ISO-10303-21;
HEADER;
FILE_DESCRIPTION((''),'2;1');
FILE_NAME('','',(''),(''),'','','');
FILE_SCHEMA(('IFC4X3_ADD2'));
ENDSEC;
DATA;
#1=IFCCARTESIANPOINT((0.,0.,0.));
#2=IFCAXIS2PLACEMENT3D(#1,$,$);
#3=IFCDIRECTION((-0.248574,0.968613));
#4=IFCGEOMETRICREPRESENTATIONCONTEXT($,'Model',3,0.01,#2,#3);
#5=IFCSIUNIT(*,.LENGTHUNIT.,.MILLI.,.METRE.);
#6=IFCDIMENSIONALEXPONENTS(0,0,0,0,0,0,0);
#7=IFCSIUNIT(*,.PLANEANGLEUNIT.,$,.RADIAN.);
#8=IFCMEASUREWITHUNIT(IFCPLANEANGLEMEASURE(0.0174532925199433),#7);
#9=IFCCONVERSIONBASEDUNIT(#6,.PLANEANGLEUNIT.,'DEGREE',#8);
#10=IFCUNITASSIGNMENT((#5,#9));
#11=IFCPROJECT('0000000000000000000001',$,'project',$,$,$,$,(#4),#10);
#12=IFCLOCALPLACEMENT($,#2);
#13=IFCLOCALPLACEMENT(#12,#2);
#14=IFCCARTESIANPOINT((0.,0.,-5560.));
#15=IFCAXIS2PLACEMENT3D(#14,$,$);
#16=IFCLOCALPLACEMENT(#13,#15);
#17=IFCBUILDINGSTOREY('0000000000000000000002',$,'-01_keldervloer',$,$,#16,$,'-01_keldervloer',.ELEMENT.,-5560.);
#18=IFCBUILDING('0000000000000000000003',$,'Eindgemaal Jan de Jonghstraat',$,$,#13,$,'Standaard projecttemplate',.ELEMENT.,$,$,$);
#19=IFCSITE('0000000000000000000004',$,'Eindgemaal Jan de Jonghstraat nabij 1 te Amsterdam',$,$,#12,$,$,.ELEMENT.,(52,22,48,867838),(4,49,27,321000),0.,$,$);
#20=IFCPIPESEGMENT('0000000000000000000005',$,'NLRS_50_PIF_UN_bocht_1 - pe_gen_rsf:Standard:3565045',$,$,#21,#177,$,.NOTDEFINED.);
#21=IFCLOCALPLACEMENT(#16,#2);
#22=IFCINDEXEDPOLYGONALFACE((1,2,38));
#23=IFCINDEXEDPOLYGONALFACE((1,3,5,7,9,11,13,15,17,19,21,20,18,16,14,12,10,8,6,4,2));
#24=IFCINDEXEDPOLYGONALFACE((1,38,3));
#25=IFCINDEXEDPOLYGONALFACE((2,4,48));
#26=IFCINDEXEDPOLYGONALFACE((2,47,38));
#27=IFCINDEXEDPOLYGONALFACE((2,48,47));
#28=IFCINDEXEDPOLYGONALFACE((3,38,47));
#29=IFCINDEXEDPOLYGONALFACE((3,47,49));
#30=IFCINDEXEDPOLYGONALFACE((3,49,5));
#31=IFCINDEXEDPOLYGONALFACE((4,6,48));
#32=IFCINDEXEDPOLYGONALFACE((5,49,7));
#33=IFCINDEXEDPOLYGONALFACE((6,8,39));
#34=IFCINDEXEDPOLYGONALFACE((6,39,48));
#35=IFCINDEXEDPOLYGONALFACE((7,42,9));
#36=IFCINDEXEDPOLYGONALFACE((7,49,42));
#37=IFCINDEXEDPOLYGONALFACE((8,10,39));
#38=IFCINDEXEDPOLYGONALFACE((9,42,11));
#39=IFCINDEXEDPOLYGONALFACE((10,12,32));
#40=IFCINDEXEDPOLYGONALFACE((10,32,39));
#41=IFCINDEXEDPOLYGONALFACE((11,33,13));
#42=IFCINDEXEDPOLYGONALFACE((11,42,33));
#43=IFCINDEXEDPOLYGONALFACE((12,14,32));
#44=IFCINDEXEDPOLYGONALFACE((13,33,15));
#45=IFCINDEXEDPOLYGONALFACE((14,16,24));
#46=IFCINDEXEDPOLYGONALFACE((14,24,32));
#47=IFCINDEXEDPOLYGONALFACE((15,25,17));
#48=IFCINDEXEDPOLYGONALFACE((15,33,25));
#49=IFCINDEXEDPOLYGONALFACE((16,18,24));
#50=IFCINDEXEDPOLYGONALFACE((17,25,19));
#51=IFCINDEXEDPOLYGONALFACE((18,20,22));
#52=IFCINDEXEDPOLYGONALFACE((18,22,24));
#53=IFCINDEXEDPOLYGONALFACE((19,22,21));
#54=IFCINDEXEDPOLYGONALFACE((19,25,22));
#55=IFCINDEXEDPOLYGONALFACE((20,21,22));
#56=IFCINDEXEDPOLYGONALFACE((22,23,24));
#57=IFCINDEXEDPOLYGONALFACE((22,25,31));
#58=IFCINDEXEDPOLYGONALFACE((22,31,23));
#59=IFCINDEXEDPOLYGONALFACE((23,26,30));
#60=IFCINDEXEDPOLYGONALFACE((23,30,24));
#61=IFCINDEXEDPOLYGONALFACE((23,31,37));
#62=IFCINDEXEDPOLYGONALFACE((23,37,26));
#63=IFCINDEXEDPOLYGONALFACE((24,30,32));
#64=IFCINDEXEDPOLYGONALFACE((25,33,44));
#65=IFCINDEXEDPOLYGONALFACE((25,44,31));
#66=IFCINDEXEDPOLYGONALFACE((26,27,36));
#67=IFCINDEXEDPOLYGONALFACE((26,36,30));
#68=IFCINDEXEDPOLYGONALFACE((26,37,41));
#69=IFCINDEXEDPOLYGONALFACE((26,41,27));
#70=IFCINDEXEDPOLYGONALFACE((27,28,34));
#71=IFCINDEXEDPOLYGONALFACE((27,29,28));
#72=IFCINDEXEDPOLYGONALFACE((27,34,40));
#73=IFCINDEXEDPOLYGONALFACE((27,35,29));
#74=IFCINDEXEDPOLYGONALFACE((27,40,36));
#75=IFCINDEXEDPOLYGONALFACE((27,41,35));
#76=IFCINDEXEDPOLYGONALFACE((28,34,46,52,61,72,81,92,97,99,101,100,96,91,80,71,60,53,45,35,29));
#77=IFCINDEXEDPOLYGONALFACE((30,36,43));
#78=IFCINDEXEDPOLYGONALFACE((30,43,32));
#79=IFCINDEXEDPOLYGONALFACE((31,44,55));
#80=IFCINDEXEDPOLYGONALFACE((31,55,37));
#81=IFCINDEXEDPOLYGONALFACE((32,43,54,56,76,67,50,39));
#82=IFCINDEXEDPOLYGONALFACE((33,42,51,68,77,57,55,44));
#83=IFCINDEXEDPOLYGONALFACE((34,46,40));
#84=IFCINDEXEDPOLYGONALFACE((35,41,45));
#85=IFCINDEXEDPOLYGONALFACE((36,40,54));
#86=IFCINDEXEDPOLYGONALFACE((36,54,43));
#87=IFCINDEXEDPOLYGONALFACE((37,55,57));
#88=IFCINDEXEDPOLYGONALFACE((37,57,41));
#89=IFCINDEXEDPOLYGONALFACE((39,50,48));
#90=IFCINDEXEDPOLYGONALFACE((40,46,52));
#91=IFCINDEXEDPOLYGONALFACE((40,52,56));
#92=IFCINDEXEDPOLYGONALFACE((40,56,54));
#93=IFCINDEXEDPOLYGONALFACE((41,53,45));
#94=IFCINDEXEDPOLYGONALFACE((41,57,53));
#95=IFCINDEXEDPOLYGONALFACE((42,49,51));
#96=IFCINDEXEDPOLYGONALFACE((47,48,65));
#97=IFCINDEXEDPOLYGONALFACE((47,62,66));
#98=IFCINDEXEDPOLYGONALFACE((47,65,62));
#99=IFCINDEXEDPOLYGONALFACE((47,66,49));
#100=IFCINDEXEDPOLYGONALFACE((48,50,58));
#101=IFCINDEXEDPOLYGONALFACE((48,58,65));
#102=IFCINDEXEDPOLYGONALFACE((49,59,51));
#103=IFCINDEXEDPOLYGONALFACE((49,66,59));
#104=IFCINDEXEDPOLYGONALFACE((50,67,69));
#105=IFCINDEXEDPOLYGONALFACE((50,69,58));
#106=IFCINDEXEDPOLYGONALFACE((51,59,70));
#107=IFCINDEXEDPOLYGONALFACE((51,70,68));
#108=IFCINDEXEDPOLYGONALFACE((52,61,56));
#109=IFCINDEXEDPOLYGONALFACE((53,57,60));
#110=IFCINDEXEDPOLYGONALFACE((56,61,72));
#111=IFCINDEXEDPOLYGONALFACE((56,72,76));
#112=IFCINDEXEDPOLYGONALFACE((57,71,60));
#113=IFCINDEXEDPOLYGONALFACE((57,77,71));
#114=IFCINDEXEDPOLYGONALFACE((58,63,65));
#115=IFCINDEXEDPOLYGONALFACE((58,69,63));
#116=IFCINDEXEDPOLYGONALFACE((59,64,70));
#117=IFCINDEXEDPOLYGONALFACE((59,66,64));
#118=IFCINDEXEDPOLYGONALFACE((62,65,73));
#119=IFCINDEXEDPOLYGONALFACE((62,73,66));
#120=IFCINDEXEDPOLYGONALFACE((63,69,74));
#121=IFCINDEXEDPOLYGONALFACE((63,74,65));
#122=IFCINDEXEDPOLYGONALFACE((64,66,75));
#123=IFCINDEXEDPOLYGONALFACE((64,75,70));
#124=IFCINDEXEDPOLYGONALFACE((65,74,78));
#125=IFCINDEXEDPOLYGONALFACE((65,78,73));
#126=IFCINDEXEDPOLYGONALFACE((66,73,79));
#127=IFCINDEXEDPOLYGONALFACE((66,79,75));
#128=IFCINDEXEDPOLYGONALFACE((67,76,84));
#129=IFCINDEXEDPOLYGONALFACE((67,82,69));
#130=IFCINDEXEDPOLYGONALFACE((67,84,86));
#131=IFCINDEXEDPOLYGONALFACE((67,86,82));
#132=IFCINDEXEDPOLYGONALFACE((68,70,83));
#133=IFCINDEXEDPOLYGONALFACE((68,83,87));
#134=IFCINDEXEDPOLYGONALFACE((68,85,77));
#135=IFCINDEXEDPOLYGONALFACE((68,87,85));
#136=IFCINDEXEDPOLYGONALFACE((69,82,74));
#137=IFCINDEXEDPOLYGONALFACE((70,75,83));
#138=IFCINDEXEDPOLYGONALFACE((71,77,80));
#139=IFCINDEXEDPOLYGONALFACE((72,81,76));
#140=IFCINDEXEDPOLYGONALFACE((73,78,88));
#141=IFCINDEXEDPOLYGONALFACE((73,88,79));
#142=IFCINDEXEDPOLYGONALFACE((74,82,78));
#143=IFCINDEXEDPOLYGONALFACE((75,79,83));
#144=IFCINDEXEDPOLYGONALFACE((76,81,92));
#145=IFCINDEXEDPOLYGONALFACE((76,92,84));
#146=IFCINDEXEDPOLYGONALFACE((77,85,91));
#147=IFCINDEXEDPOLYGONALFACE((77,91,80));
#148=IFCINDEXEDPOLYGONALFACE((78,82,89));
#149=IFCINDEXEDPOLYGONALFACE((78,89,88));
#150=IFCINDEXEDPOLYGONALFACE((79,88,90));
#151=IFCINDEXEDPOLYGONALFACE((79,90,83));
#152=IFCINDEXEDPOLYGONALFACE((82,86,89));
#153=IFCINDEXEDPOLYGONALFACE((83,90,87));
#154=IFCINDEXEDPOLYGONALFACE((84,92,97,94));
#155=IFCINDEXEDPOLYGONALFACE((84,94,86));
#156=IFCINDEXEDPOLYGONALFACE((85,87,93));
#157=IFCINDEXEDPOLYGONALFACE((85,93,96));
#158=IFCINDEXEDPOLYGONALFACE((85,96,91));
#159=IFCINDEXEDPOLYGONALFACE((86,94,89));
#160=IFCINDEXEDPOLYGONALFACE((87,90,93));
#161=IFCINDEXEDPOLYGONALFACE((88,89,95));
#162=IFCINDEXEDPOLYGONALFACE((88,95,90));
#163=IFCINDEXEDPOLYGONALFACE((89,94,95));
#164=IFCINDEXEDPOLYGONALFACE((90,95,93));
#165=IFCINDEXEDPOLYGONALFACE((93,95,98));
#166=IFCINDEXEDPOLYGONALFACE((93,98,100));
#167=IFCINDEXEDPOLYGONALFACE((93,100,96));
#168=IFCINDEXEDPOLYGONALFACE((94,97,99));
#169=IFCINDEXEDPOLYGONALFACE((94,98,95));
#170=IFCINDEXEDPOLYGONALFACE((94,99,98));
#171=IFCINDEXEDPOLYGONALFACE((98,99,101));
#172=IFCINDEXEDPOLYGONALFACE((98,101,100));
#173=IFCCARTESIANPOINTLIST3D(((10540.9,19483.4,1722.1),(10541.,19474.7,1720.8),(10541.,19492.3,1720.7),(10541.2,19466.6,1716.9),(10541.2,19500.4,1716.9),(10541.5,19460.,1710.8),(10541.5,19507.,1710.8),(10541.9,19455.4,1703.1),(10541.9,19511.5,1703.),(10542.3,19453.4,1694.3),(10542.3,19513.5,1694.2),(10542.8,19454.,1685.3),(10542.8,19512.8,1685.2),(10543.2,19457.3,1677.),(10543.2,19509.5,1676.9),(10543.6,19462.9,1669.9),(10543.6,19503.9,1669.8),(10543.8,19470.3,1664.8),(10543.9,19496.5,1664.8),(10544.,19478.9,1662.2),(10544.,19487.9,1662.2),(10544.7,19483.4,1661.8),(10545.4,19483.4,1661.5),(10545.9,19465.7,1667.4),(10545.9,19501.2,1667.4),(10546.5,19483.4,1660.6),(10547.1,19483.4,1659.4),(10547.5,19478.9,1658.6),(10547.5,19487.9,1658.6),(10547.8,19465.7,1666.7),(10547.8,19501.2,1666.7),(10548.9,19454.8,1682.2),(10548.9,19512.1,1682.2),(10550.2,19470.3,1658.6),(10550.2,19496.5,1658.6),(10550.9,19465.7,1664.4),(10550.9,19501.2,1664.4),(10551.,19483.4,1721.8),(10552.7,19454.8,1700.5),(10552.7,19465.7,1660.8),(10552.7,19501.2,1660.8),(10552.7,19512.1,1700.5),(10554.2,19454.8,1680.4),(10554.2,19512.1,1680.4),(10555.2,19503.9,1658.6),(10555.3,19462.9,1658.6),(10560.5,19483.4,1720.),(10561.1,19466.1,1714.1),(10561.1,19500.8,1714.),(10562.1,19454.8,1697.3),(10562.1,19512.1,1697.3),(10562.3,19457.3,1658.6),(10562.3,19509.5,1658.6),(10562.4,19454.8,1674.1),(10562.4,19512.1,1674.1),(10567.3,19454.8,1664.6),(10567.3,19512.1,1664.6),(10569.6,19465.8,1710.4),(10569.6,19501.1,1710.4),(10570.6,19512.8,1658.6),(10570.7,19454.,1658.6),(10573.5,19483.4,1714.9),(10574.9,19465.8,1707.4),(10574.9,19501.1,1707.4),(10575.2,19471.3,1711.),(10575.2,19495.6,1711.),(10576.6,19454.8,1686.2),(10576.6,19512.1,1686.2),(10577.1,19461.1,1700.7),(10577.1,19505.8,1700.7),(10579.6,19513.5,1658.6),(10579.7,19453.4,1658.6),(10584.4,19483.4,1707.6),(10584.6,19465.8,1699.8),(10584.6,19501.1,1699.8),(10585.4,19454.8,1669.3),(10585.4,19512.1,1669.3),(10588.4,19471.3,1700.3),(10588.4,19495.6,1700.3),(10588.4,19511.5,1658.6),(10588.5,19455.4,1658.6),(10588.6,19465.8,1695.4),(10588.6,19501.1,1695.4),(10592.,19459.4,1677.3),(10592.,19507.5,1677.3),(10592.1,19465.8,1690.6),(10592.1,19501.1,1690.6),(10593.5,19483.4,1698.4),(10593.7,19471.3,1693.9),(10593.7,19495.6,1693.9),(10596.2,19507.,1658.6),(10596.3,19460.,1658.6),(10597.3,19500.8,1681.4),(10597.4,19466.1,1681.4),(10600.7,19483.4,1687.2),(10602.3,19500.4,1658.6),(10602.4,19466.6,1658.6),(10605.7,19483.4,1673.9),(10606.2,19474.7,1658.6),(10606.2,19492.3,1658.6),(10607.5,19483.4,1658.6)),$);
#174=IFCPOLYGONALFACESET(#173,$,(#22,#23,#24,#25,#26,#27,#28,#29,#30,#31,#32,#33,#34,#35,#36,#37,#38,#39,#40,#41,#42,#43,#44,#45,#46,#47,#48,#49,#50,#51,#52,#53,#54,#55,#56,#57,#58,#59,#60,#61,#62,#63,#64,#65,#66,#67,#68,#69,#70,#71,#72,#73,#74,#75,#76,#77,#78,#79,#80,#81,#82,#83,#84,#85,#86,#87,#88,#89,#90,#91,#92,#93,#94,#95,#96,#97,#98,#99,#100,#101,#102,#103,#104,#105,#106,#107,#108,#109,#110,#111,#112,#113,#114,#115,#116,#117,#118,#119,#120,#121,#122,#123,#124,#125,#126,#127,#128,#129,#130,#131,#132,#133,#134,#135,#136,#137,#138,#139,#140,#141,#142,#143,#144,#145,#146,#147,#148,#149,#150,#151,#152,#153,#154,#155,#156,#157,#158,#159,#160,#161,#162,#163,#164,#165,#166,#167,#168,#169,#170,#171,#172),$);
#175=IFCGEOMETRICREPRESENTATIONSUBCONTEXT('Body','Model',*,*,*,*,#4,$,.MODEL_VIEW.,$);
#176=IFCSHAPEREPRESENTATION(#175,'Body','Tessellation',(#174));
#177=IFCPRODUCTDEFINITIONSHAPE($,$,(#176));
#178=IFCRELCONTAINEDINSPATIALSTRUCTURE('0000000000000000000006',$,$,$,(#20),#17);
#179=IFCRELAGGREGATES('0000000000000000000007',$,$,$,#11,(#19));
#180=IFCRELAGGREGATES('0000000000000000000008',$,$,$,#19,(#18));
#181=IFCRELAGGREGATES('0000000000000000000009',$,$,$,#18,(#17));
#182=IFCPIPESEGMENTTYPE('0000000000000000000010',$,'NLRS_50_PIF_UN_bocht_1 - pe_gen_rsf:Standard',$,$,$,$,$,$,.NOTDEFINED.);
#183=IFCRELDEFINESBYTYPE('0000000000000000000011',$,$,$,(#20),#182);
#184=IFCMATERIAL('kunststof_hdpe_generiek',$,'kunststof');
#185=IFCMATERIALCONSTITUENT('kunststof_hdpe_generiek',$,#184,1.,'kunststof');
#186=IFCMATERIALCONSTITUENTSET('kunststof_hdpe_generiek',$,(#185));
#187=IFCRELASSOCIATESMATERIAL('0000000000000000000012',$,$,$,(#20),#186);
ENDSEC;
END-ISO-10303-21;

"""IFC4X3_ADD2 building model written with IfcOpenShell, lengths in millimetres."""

from ifc_helpers import new_model, entity, si_unit, converted_unit, direction, frame, origin, place, context, subcontext, project, spatial, source, transform, mapped, material, constituent, constituent_set, type_object, type_shapes, element, save


model = new_model("IFC4X3_ADD2")

# Units and contexts
model_context = context("Model", 3, precision=0.01, world=origin(), true_north=direction((-0.248574, 0.968613)))
body_context = subcontext(model_context, "Body", "Model", "MODEL_VIEW")
ifc_project = project(units=[si_unit("LENGTHUNIT", "METRE", prefix="MILLI"), converted_unit("PLANEANGLEUNIT", "DEGREE", entity("IfcPlaneAngleMeasure", 0.0174532925199433), si_unit("PLANEANGLEUNIT", "RADIAN"), dimensions=[0, 0, 0, 0, 0, 0, 0])], contexts=[model_context])

# Site, building, storey
site_placement = place(None, origin())
site = spatial("IfcSite", under=ifc_project, at=site_placement, Name="Eindgemaal Jan de Jonghstraat nabij 1 te Amsterdam", CompositionType="ELEMENT", RefLatitude=(52, 22, 48, 867838), RefLongitude=(4, 49, 27, 321000), RefElevation=0.0)
building_placement = place(site_placement, origin())
building = spatial("IfcBuilding", under=site, at=building_placement, Name="Eindgemaal Jan de Jonghstraat", LongName="Standaard projecttemplate", CompositionType="ELEMENT")
storey_placement = place(building_placement, frame((0.0, 0.0, -5560.0)))
storey = spatial("IfcBuildingStorey", under=building, at=storey_placement, Name="-01_keldervloer", LongName="-01_keldervloer", CompositionType="ELEMENT", Elevation=-5560.0)

# Pipe segment
ifc_material_1 = material(Name="kunststof_hdpe_generiek", Category="kunststof")
ifc_constituent_1 = constituent(ifc_material_1, Name="kunststof_hdpe_generiek", Category="kunststof", fraction=1.0)
ifc_constituent_set_1 = constituent_set(constituents=[ifc_constituent_1], Name="kunststof_hdpe_generiek")
pipe_segment_type_1 = type_object("IfcPipeSegmentType", Name="NLRS_50_PIF_UN_bocht_1 - pe_gen_rsf:Standard", PredefinedType="NOTDEFINED")
trimmed_curve_1 = entity("IfcTrimmedCurve", entity("IfcCircle", entity("IfcAxis2Placement2D", entity("IfcCartesianPoint", [-3.2, 0.0]), entity("IfcDirection", [0.0, 1.0])), 3.2), [entity("IfcParameterValue", 270.0)], [entity("IfcParameterValue", 0.0)], True, "PARAMETER")
shared_shape_1 = source(origin(), body_context, "Body", "AdvancedSweptSolid", [
    entity("IfcSurfaceCurveSweptAreaSolid", entity("IfcCircleProfileDef", "AREA", None, entity("IfcAxis2Placement2D", entity("IfcCartesianPoint", [30.1, 0.0]), entity("IfcDirection", [1.0, 0.0])), 30.1), entity("IfcAxis2Placement3D", entity("IfcCartesianPoint", [-30.1, 33.3, 0.0]), entity("IfcDirection", [0.0, 0.0, -1.0]), entity("IfcDirection", [1.0, 0.0, 0.0])), trimmed_curve_1, entity("IfcParameterValue", 0.0), entity("IfcParameterValue", 90.0), entity("IfcSurfaceOfLinearExtrusion", entity("IfcArbitraryOpenProfileDef", "CURVE", None, trimmed_curve_1), entity("IfcAxis2Placement3D", entity("IfcCartesianPoint", [0.0, 0.0, -304.8])), entity("IfcDirection", [0.0, 0.0, 1.0]), 1.0)),
])
type_shapes(pipe_segment_type_1, [shared_shape_1])
pipe_segment_1_placement = place(storey_placement, frame((10577.4, 19483.4, 1692.0), z_axis=(0.0, 1.0, 0.0), x_axis=(1.0, 0.0, 0.0)))
element("IfcPipeSegment", 1, at=pipe_segment_1_placement, inside=storey, type_object=pipe_segment_type_1, material=ifc_constituent_set_1, Name="NLRS_50_PIF_UN_bocht_1 - pe_gen_rsf:Standard:3565045", PredefinedType="NOTDEFINED", context=body_context, shape_type="MappedRepresentation", body=[
    mapped(shared_shape_1, transform((0.0, 0.0, 0.0), scale=1.0)),
])

save(model, "model.ifc")
